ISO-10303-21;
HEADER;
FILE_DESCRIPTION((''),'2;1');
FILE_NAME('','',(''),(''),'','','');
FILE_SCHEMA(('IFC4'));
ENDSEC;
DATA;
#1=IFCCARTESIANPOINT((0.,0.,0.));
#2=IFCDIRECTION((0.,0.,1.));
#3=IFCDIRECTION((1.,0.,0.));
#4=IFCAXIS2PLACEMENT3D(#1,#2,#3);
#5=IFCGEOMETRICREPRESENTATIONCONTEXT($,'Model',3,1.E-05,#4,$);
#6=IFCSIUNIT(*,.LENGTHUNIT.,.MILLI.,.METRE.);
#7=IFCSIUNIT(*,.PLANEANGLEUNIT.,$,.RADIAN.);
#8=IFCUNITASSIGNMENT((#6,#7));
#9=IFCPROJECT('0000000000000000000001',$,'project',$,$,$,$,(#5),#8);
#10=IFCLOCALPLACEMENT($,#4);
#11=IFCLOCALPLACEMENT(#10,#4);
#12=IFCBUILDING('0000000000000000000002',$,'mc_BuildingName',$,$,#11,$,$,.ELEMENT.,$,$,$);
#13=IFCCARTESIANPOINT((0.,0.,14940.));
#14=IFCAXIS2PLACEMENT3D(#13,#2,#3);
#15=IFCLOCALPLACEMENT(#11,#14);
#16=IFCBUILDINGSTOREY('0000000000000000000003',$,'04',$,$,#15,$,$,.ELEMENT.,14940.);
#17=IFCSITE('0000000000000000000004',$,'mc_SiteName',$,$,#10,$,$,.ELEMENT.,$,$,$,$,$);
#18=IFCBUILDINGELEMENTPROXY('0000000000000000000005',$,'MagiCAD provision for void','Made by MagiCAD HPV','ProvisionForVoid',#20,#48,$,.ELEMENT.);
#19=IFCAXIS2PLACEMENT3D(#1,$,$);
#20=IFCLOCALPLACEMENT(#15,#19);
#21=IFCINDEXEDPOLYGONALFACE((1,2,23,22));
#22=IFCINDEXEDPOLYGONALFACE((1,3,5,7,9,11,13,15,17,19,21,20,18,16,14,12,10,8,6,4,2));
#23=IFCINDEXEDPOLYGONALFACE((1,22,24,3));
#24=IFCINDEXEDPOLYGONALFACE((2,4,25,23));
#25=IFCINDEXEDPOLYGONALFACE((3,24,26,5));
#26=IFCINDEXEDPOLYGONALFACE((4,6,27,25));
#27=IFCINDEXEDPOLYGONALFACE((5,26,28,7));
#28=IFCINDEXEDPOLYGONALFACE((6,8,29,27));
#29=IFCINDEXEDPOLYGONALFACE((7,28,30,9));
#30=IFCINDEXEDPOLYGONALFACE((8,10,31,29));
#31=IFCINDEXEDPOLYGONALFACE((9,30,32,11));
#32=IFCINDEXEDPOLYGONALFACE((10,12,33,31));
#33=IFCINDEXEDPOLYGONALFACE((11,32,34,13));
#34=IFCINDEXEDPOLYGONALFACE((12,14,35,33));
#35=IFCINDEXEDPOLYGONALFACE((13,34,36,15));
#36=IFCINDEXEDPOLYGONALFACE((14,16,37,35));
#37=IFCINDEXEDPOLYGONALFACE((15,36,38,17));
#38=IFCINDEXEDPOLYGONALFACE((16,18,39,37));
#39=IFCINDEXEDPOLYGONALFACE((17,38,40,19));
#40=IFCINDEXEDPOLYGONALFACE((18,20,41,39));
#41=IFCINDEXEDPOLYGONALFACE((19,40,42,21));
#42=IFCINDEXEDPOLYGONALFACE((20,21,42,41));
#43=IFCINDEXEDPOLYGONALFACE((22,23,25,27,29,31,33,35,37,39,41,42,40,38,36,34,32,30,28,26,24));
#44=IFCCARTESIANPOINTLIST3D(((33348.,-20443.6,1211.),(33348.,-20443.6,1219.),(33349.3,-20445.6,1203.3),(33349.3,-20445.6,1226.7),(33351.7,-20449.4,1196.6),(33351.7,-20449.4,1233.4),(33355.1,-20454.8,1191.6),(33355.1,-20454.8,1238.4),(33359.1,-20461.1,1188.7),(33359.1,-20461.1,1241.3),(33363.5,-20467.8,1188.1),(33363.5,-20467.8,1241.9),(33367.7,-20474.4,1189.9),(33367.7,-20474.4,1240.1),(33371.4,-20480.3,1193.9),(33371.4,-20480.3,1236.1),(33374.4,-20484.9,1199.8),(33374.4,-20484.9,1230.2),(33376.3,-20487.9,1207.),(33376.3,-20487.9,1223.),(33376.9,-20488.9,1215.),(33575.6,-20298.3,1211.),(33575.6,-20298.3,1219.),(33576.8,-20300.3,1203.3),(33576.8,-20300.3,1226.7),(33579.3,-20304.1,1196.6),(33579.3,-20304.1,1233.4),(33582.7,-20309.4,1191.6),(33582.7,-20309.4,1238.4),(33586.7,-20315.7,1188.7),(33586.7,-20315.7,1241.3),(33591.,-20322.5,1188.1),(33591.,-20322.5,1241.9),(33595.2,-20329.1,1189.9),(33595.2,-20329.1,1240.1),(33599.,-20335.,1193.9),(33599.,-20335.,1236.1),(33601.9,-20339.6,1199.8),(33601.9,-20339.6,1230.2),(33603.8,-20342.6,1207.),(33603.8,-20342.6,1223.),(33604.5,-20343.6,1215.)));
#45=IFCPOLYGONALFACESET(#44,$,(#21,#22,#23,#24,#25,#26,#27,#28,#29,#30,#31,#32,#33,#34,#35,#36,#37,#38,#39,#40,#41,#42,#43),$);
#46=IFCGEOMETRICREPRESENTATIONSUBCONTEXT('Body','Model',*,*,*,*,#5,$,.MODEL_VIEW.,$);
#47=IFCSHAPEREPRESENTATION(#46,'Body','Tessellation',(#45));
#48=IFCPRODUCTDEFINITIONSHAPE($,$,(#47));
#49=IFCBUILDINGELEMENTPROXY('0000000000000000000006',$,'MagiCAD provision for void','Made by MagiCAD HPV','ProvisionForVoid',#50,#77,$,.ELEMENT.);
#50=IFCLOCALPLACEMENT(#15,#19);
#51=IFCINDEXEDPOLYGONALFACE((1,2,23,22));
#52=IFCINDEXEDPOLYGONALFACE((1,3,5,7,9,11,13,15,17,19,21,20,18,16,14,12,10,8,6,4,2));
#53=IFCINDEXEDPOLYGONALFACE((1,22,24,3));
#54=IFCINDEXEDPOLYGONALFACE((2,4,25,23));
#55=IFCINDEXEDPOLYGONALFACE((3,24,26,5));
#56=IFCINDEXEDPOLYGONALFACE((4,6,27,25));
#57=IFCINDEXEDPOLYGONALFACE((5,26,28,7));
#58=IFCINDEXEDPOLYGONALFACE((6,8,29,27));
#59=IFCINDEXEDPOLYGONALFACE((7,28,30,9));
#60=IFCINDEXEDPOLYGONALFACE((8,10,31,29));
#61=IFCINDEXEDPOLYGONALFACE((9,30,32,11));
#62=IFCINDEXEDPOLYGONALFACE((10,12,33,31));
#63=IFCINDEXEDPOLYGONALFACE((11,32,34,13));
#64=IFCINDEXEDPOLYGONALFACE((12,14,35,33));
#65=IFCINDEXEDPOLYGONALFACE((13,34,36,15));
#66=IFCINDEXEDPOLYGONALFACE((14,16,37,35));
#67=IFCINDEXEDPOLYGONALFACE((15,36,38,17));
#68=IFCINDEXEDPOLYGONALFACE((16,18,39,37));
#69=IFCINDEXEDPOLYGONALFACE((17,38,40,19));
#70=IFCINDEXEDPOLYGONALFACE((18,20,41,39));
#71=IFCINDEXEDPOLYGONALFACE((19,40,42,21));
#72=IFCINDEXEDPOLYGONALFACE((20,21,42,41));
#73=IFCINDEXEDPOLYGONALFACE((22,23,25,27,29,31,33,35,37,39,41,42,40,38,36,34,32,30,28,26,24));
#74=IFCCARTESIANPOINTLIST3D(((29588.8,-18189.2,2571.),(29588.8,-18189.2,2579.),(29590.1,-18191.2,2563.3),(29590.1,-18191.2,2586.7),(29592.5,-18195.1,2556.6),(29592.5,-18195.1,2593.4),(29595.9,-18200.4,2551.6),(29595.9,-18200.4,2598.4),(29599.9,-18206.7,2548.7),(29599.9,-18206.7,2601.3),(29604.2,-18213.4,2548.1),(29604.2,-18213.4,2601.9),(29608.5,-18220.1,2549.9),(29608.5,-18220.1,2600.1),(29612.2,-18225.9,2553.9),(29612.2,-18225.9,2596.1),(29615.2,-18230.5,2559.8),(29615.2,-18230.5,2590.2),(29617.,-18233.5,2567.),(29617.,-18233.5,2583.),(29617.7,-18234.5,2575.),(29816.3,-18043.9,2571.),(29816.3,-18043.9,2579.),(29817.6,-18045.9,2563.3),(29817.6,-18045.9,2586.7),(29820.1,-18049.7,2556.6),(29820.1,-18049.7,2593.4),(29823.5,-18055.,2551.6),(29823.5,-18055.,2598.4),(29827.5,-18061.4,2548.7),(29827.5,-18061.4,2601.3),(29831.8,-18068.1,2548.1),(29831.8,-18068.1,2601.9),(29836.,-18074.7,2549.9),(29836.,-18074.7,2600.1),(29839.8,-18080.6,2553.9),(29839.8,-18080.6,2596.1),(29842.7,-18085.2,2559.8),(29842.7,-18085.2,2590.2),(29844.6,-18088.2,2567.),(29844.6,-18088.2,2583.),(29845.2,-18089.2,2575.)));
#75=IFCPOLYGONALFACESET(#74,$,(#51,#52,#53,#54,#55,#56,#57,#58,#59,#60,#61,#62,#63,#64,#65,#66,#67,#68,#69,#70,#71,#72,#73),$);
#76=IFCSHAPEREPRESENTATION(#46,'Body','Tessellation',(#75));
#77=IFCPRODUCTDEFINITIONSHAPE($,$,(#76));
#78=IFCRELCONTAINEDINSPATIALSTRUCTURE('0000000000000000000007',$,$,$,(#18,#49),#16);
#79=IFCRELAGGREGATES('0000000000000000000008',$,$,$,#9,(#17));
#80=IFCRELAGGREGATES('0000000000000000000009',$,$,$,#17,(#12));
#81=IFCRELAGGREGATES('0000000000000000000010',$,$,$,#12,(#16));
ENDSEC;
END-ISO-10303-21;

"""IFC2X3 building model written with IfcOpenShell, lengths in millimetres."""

from ifc_helpers import new_model, si_unit, frame, origin_with_axes, origin_2d_with_axis, place, context, subcontext, project, spatial, circle, extrude, source, transform, mapped, element, save


model = new_model("IFC2X3")

# Units and contexts
model_context = context("Model", 3, precision=1e-05, world=origin_with_axes())
body_context = subcontext(model_context, "Body", "Model", "MODEL_VIEW")
ifc_project = project(units=[si_unit("LENGTHUNIT", "METRE", prefix="MILLI"), si_unit("PLANEANGLEUNIT", "RADIAN")], contexts=[model_context])

# Site, building, storey
site_placement = place(None, origin_with_axes())
site = spatial("IfcSite", under=ifc_project, at=site_placement, Name="mc_SiteName", CompositionType="ELEMENT")
building_placement = place(site_placement, origin_with_axes())
building = spatial("IfcBuilding", under=site, at=building_placement, Name="mc_BuildingName", CompositionType="ELEMENT")
storey_placement = place(building_placement, frame((0.0, 0.0, 14940.0), z_axis=(0.0, 0.0, 1.0), x_axis=(1.0, 0.0, 0.0)))
storey = spatial("IfcBuildingStorey", under=building, at=storey_placement, Name="04", CompositionType="ELEMENT", Elevation=14940.0)

# Building element proxies
shared_shape_1 = source(origin_with_axes(), body_context, "Body", "SweptSolid", [
    extrude(circle(Radius=27.0, at=origin_2d_with_axis()), frame((0.0, 0.0, 0.0), z_axis=(1.0, 0.0, 0.0), x_axis=(0.0, 1.0, 0.0)), (0.0, 0.0, 1.0), 270.0),
])
proxy_1_placement = place(storey_placement, frame((33589.9, -20320.8, 1215.0), z_axis=(0.0, 0.0, 1.0), x_axis=(-0.842809, -0.538213, 0.0)))
element("IfcBuildingElementProxy", 1, at=proxy_1_placement, inside=storey, Name="MagiCAD provision for void", Description="Made by MagiCAD HPV", ObjectType="ProvisionForVoid", CompositionType="ELEMENT", context=body_context, shape_type="MappedRepresentation", body=[
    mapped(shared_shape_1, transform((0.0, 0.0, 0.0), scale=1.0)),
])
shared_shape_2 = source(origin_with_axes(), body_context, "Body", "SweptSolid", [
    extrude(circle(Radius=27.0, at=origin_2d_with_axis()), frame((0.0, 0.0, 0.0), z_axis=(1.0, 0.0, 0.0), x_axis=(0.0, 1.0, 0.0)), (0.0, 0.0, 1.0), 270.0),
])
proxy_2_placement = place(storey_placement, frame((29830.7, -18066.4, 2575.0), z_axis=(0.0, 0.0, 1.0), x_axis=(-0.842809, -0.538213, 0.0)))
element("IfcBuildingElementProxy", 2, at=proxy_2_placement, inside=storey, Name="MagiCAD provision for void", Description="Made by MagiCAD HPV", ObjectType="ProvisionForVoid", CompositionType="ELEMENT", context=body_context, shape_type="MappedRepresentation", body=[
    mapped(shared_shape_2, transform((0.0, 0.0, 0.0), scale=1.0)),
])

save(model, "model.ifc")
